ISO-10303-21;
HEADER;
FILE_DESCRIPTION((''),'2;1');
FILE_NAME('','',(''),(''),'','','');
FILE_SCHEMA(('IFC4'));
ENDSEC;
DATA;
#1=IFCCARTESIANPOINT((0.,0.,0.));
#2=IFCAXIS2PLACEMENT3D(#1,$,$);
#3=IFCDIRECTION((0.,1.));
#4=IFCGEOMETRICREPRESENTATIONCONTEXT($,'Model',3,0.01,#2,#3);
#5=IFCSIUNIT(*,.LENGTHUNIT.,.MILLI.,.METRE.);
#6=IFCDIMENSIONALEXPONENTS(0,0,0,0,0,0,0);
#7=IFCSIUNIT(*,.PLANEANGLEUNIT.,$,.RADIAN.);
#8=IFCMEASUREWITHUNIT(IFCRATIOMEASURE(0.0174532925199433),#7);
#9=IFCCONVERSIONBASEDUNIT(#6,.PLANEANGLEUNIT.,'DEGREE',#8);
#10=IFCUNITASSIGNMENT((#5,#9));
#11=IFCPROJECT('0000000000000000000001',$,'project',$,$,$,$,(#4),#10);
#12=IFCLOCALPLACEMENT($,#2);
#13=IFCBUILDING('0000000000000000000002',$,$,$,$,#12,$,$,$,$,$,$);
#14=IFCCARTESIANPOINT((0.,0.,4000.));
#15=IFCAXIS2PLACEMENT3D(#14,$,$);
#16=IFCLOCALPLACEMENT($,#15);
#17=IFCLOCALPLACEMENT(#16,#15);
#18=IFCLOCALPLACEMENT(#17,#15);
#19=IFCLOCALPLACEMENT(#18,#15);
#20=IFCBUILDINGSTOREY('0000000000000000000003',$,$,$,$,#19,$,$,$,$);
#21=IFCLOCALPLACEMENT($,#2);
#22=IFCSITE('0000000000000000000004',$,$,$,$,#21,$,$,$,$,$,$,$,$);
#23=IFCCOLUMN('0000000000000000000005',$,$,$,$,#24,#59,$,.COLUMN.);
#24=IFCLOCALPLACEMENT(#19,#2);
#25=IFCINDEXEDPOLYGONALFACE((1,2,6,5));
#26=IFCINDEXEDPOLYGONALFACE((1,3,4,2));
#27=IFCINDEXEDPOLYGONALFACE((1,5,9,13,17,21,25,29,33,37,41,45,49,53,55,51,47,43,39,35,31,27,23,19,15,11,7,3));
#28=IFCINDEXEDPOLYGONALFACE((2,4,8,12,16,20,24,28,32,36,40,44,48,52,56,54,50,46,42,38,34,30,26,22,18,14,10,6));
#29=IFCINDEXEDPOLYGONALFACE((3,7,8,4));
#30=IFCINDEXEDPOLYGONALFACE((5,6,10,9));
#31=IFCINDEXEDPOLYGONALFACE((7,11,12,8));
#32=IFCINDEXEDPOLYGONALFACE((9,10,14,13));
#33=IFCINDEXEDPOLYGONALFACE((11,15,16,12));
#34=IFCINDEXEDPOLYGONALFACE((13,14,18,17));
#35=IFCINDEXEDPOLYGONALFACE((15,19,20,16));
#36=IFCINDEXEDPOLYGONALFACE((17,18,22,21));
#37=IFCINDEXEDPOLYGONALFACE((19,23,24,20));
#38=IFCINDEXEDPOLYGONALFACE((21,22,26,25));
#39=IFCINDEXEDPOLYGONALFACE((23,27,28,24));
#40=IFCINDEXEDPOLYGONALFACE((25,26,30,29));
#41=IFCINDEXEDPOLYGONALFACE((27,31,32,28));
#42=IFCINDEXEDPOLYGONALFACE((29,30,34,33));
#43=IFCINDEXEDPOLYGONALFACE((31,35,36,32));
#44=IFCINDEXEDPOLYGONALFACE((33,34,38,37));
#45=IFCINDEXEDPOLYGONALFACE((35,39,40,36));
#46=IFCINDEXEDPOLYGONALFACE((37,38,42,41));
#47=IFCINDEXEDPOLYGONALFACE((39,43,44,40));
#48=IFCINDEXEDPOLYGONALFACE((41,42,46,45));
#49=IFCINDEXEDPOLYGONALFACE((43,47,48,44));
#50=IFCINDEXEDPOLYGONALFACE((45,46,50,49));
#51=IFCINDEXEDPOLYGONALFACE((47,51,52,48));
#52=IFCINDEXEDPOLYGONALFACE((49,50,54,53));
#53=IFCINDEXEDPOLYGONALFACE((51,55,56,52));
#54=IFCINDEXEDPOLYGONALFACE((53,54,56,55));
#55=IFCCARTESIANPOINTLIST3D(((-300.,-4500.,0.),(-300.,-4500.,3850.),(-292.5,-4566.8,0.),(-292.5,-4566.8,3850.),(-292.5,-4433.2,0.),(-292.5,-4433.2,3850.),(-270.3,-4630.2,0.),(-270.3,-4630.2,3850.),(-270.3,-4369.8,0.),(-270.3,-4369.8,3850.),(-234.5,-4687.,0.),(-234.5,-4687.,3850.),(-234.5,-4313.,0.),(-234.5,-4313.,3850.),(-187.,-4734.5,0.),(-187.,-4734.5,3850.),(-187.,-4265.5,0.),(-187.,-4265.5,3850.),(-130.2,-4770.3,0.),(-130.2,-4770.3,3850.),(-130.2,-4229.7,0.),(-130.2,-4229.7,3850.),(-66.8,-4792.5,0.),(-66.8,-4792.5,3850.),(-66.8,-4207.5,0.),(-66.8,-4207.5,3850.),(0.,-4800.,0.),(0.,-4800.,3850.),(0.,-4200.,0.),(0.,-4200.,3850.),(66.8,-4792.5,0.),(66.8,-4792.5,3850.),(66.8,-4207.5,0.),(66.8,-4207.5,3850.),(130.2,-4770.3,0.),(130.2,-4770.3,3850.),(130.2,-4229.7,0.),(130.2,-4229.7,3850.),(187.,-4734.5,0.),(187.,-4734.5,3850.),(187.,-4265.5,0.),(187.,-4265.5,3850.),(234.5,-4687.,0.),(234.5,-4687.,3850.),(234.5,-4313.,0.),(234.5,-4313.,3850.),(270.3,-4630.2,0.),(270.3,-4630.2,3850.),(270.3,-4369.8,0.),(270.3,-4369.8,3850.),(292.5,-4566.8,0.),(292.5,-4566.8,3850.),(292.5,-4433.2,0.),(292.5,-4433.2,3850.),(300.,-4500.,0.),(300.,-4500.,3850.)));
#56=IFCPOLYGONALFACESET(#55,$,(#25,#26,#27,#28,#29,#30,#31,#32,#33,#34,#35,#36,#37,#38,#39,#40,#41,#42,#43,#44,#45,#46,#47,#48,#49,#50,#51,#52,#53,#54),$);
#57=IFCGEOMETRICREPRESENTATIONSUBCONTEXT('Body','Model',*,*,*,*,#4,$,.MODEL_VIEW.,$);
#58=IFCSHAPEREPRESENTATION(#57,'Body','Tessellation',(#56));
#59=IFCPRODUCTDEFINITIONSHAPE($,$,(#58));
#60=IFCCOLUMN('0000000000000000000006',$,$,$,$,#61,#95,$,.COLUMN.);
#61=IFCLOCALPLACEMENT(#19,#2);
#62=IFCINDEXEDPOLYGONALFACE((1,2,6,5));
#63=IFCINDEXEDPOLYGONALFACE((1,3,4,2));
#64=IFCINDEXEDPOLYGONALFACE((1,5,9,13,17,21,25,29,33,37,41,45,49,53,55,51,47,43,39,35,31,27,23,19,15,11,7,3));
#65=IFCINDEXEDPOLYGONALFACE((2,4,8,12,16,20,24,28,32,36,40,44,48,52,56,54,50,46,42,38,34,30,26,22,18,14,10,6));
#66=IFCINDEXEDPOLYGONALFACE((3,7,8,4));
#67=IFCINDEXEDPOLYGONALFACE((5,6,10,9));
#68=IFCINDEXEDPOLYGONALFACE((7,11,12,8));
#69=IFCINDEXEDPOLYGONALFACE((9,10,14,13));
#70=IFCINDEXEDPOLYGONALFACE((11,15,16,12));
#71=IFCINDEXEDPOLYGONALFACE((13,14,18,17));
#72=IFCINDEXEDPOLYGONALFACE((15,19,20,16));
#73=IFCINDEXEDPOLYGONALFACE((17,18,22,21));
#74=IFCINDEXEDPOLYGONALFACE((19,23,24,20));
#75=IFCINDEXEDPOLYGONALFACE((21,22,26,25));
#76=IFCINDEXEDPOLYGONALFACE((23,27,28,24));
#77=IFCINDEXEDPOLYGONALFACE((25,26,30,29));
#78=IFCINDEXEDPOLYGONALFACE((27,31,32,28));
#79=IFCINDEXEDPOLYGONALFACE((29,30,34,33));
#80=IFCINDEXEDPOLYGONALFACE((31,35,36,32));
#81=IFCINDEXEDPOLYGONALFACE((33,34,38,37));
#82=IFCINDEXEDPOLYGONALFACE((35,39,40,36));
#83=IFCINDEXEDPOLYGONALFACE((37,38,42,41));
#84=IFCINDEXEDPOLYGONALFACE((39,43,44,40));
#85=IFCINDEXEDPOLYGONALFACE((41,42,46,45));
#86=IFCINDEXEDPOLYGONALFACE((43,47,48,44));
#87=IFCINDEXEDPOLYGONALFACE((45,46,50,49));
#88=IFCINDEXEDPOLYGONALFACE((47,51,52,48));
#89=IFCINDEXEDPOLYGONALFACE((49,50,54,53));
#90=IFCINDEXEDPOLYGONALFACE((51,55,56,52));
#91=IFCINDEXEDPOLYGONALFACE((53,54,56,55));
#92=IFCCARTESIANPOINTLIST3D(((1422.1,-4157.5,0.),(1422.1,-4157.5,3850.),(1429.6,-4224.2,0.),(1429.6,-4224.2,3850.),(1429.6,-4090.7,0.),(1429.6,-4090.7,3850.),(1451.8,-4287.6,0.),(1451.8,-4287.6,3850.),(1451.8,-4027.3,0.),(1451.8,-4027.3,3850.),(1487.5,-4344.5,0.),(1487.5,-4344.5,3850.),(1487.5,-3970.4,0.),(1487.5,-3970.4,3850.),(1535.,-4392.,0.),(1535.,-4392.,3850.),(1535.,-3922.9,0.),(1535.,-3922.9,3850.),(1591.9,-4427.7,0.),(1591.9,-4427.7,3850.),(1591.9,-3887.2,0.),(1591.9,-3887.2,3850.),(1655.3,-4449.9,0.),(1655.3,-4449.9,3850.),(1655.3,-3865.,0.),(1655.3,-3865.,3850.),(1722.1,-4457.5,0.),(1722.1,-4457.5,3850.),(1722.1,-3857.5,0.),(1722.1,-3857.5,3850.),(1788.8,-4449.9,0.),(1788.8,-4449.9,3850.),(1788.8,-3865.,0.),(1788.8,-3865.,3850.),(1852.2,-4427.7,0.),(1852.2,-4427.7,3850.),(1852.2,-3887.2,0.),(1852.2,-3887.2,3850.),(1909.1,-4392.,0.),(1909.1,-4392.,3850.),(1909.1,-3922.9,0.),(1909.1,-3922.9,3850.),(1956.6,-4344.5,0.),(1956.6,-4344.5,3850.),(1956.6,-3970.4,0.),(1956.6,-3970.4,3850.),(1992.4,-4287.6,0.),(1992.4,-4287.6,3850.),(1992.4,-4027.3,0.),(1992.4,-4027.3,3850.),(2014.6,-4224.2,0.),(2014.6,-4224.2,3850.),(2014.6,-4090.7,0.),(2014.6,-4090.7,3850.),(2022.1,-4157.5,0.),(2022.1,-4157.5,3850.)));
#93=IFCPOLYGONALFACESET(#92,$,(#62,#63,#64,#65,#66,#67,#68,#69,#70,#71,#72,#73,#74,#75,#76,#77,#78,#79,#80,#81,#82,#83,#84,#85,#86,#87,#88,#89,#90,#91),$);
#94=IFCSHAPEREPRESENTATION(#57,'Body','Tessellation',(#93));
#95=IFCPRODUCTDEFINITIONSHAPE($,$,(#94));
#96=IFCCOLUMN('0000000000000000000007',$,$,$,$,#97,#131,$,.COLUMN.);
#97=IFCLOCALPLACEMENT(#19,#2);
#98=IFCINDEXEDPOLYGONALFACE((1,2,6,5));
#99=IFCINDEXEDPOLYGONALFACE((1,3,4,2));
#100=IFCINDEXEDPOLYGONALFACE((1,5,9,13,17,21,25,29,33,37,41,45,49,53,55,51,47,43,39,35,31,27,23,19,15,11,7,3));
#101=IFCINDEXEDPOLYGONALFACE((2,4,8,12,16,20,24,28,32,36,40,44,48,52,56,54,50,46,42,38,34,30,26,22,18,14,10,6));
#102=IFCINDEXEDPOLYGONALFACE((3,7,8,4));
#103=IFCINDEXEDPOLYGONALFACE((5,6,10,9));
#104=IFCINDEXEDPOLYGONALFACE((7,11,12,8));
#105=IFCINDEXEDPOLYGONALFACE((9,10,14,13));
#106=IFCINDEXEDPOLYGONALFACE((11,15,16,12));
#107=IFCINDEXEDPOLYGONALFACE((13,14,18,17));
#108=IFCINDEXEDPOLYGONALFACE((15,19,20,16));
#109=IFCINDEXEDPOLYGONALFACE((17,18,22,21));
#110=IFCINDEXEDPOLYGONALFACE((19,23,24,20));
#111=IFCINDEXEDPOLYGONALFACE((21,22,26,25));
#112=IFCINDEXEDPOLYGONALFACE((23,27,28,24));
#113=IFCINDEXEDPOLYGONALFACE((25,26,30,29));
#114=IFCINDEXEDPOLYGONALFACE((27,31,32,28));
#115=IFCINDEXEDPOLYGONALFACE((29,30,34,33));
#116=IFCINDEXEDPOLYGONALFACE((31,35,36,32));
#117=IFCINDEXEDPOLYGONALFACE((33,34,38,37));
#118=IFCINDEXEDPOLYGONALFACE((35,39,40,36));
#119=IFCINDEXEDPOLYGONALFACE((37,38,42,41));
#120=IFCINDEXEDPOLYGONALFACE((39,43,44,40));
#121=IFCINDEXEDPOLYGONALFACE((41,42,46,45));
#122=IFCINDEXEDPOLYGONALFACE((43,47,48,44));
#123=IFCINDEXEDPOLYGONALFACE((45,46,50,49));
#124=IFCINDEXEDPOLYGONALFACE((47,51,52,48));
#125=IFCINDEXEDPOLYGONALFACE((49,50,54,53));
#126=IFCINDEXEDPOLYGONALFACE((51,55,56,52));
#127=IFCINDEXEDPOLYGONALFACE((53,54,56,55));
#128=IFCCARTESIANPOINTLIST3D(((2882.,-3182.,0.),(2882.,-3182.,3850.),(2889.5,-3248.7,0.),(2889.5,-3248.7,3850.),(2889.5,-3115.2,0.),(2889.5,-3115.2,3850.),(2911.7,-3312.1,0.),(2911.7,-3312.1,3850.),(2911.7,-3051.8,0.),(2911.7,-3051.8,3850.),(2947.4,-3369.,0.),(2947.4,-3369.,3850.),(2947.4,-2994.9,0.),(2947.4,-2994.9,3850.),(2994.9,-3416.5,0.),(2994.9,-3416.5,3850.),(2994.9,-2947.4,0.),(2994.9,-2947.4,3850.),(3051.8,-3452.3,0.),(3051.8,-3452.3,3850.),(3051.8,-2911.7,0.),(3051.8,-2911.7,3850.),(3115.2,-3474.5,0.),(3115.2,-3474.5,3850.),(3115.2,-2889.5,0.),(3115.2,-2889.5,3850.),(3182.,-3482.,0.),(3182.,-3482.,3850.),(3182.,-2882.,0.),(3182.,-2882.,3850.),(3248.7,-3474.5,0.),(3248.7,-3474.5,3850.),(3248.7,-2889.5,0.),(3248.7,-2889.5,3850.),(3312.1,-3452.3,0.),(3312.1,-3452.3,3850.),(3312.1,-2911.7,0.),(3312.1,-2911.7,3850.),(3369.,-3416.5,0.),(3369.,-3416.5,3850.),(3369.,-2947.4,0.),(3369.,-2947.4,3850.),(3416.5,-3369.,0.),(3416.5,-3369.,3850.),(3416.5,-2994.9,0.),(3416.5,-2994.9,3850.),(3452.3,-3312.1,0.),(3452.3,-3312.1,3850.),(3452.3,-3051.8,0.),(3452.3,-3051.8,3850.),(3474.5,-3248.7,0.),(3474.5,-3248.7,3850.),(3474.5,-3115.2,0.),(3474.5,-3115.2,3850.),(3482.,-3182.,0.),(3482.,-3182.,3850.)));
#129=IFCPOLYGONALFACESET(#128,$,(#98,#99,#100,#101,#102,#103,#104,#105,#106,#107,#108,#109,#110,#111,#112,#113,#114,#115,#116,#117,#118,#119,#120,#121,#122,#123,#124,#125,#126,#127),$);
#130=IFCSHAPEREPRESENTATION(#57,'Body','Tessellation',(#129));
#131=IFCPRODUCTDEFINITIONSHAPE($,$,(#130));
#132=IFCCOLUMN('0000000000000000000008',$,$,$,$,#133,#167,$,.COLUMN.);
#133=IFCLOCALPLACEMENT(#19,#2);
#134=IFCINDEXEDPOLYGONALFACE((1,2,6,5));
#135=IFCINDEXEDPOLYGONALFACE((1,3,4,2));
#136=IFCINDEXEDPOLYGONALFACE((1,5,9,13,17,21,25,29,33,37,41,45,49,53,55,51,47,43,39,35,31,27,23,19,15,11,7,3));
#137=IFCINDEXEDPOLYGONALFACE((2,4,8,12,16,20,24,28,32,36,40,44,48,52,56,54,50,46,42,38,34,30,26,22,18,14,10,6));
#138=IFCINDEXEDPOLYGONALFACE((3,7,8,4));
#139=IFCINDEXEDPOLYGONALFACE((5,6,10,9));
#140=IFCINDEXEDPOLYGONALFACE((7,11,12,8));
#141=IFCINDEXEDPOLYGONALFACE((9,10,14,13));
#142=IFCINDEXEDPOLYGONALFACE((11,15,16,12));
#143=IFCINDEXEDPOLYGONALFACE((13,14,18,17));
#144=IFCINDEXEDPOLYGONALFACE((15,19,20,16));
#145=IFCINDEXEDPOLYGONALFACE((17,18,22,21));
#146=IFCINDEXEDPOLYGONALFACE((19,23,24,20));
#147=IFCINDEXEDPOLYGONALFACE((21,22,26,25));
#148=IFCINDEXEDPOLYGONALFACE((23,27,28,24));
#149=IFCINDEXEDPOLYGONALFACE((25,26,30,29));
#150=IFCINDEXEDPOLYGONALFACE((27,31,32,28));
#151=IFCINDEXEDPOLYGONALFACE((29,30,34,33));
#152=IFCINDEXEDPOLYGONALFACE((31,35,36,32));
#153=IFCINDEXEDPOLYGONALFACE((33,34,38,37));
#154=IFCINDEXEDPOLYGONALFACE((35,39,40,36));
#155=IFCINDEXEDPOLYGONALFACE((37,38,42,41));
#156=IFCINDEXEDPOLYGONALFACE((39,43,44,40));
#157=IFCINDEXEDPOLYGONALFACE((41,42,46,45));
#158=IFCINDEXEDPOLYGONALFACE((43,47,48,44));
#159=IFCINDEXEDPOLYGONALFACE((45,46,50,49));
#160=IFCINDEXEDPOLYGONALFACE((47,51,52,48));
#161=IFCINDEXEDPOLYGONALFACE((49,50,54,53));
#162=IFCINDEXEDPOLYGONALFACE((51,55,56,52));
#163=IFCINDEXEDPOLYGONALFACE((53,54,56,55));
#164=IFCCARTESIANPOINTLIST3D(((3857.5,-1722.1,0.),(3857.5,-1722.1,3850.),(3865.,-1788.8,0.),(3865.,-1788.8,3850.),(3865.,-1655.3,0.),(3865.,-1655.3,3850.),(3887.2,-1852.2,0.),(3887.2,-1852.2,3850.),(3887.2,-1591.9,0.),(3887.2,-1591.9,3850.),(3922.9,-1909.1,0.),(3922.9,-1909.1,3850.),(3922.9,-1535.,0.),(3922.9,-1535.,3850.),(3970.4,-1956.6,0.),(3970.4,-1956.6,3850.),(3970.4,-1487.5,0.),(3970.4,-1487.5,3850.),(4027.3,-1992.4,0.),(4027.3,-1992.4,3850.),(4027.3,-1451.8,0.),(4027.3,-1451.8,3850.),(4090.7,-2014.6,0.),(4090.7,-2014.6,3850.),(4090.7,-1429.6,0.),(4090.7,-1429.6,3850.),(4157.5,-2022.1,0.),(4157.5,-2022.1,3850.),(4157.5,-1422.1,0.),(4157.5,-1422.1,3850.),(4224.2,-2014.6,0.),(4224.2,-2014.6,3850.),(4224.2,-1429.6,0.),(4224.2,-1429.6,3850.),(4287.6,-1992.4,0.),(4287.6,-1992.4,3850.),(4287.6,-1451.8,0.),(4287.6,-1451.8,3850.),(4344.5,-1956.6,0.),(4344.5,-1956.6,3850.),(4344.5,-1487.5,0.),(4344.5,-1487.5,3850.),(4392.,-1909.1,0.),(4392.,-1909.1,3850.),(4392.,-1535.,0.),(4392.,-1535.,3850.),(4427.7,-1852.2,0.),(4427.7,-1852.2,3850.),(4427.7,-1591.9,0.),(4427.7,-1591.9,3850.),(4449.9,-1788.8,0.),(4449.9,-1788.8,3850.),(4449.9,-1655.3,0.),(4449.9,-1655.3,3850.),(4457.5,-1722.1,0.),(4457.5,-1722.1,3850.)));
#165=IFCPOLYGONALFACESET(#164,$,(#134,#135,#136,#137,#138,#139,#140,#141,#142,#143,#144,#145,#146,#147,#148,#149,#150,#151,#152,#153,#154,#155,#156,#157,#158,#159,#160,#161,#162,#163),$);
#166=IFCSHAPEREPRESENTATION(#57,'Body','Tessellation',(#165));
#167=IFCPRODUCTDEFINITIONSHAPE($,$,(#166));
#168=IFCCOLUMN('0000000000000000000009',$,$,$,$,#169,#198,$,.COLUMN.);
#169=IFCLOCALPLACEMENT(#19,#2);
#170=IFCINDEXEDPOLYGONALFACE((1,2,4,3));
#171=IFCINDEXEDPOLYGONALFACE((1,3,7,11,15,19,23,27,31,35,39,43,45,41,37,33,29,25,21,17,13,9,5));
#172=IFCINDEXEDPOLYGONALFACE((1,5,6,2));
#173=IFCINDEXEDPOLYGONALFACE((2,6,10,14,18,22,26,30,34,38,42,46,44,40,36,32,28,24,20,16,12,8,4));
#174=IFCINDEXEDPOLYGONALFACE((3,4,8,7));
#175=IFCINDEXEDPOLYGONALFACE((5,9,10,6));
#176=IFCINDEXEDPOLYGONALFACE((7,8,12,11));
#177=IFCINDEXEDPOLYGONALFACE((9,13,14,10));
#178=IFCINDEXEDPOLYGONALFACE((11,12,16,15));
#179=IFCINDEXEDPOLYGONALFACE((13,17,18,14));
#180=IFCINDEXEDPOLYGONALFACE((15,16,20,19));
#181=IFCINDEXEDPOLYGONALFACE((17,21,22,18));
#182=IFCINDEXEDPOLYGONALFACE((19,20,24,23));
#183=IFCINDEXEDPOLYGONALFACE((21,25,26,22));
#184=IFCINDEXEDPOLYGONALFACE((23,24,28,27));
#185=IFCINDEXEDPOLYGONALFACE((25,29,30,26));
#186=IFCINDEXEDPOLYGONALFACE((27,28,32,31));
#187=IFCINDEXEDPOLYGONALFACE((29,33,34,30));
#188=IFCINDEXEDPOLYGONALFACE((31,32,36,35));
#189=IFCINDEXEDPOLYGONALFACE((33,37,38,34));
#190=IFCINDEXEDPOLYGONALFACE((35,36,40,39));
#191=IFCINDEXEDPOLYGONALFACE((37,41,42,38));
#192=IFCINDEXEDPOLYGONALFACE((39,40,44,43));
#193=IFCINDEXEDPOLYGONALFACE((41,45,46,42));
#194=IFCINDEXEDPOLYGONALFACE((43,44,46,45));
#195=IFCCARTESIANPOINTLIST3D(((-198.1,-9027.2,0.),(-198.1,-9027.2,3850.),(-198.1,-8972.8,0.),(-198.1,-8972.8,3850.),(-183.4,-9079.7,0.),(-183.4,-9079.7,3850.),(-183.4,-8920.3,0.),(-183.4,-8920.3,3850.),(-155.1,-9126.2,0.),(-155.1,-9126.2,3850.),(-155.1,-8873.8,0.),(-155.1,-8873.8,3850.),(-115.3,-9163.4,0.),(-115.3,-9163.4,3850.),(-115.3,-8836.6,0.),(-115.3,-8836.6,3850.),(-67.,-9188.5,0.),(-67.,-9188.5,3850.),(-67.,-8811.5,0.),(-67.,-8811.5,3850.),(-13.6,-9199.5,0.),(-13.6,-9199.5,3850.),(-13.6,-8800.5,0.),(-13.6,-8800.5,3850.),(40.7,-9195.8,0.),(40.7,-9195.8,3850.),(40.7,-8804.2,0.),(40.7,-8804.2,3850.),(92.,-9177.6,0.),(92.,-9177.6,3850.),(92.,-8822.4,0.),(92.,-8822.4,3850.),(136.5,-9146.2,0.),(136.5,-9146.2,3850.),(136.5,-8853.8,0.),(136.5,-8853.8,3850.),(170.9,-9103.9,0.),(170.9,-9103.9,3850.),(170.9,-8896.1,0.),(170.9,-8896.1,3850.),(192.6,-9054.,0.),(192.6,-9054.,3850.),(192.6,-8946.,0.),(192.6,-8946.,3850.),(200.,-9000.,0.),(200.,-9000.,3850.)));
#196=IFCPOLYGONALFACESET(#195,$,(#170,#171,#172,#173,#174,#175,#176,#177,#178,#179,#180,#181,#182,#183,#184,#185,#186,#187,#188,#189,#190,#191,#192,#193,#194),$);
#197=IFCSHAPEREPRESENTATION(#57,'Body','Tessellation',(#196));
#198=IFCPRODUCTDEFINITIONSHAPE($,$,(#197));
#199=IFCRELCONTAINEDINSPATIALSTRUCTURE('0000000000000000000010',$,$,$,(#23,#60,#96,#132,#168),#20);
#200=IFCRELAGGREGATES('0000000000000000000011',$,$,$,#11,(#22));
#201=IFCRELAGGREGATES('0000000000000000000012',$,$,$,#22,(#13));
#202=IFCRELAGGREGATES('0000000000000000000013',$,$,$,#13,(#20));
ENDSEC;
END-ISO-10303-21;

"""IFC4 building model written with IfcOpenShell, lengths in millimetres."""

from ifc_helpers import new_model, entity, si_unit, converted_unit, direction, frame, origin, origin_2d, place, context, subcontext, project, spatial, circle, extrude, element, save


model = new_model("IFC4")

# Units and contexts
model_context = context("Model", 3, precision=0.01, world=origin(), true_north=direction((0.0, 1.0)))
body_context = subcontext(model_context, "Body", "Model", "MODEL_VIEW")
ifc_project = project(units=[si_unit("LENGTHUNIT", "METRE", prefix="MILLI"), converted_unit("PLANEANGLEUNIT", "DEGREE", entity("IfcRatioMeasure", 0.0174532925199433), si_unit("PLANEANGLEUNIT", "RADIAN"), dimensions=[0, 0, 0, 0, 0, 0, 0])], contexts=[model_context])

# Site, building, storey
site_placement = place(None, origin())
site = spatial("IfcSite", under=ifc_project, at=site_placement)
building_placement = place(None, origin())
building = spatial("IfcBuilding", under=site, at=building_placement)
placement_1 = place(None, frame((0.0, 0.0, 4000.0)))
placement_2 = place(placement_1, frame((0.0, 0.0, 4000.0)))
placement_3 = place(placement_2, frame((0.0, 0.0, 4000.0)))
storey_placement = place(placement_3, frame((0.0, 0.0, 4000.0)))
storey = spatial("IfcBuildingStorey", under=building, at=storey_placement)

# Columns
for number, where in (
    (1, (0.0, -4500.0, 0.0)),
    (2, (1722.1, -4157.5, 0.0)),
    (3, (3182.0, -3182.0, 0.0)),
    (4, (4157.5, -1722.1, 0.0)),
):
    element("IfcColumn", number, at=place(storey_placement, frame(where)), inside=storey, PredefinedType="COLUMN", context=body_context, shape_type="SweptSolid", body=[
        extrude(circle(Radius=300.0, at=origin_2d()), origin(), (0.0, 0.0, 1.0), 3850.0),
    ])
for number, where in (
    (5, (0.0, -9000.0, 0.0)),
):
    element("IfcColumn", number, at=place(storey_placement, frame(where)), inside=storey, PredefinedType="COLUMN", context=body_context, shape_type="SweptSolid", body=[
        extrude(circle(Radius=200.0, at=origin_2d()), origin(), (0.0, 0.0, 1.0), 3850.0),
    ])

save(model, "model.ifc")
